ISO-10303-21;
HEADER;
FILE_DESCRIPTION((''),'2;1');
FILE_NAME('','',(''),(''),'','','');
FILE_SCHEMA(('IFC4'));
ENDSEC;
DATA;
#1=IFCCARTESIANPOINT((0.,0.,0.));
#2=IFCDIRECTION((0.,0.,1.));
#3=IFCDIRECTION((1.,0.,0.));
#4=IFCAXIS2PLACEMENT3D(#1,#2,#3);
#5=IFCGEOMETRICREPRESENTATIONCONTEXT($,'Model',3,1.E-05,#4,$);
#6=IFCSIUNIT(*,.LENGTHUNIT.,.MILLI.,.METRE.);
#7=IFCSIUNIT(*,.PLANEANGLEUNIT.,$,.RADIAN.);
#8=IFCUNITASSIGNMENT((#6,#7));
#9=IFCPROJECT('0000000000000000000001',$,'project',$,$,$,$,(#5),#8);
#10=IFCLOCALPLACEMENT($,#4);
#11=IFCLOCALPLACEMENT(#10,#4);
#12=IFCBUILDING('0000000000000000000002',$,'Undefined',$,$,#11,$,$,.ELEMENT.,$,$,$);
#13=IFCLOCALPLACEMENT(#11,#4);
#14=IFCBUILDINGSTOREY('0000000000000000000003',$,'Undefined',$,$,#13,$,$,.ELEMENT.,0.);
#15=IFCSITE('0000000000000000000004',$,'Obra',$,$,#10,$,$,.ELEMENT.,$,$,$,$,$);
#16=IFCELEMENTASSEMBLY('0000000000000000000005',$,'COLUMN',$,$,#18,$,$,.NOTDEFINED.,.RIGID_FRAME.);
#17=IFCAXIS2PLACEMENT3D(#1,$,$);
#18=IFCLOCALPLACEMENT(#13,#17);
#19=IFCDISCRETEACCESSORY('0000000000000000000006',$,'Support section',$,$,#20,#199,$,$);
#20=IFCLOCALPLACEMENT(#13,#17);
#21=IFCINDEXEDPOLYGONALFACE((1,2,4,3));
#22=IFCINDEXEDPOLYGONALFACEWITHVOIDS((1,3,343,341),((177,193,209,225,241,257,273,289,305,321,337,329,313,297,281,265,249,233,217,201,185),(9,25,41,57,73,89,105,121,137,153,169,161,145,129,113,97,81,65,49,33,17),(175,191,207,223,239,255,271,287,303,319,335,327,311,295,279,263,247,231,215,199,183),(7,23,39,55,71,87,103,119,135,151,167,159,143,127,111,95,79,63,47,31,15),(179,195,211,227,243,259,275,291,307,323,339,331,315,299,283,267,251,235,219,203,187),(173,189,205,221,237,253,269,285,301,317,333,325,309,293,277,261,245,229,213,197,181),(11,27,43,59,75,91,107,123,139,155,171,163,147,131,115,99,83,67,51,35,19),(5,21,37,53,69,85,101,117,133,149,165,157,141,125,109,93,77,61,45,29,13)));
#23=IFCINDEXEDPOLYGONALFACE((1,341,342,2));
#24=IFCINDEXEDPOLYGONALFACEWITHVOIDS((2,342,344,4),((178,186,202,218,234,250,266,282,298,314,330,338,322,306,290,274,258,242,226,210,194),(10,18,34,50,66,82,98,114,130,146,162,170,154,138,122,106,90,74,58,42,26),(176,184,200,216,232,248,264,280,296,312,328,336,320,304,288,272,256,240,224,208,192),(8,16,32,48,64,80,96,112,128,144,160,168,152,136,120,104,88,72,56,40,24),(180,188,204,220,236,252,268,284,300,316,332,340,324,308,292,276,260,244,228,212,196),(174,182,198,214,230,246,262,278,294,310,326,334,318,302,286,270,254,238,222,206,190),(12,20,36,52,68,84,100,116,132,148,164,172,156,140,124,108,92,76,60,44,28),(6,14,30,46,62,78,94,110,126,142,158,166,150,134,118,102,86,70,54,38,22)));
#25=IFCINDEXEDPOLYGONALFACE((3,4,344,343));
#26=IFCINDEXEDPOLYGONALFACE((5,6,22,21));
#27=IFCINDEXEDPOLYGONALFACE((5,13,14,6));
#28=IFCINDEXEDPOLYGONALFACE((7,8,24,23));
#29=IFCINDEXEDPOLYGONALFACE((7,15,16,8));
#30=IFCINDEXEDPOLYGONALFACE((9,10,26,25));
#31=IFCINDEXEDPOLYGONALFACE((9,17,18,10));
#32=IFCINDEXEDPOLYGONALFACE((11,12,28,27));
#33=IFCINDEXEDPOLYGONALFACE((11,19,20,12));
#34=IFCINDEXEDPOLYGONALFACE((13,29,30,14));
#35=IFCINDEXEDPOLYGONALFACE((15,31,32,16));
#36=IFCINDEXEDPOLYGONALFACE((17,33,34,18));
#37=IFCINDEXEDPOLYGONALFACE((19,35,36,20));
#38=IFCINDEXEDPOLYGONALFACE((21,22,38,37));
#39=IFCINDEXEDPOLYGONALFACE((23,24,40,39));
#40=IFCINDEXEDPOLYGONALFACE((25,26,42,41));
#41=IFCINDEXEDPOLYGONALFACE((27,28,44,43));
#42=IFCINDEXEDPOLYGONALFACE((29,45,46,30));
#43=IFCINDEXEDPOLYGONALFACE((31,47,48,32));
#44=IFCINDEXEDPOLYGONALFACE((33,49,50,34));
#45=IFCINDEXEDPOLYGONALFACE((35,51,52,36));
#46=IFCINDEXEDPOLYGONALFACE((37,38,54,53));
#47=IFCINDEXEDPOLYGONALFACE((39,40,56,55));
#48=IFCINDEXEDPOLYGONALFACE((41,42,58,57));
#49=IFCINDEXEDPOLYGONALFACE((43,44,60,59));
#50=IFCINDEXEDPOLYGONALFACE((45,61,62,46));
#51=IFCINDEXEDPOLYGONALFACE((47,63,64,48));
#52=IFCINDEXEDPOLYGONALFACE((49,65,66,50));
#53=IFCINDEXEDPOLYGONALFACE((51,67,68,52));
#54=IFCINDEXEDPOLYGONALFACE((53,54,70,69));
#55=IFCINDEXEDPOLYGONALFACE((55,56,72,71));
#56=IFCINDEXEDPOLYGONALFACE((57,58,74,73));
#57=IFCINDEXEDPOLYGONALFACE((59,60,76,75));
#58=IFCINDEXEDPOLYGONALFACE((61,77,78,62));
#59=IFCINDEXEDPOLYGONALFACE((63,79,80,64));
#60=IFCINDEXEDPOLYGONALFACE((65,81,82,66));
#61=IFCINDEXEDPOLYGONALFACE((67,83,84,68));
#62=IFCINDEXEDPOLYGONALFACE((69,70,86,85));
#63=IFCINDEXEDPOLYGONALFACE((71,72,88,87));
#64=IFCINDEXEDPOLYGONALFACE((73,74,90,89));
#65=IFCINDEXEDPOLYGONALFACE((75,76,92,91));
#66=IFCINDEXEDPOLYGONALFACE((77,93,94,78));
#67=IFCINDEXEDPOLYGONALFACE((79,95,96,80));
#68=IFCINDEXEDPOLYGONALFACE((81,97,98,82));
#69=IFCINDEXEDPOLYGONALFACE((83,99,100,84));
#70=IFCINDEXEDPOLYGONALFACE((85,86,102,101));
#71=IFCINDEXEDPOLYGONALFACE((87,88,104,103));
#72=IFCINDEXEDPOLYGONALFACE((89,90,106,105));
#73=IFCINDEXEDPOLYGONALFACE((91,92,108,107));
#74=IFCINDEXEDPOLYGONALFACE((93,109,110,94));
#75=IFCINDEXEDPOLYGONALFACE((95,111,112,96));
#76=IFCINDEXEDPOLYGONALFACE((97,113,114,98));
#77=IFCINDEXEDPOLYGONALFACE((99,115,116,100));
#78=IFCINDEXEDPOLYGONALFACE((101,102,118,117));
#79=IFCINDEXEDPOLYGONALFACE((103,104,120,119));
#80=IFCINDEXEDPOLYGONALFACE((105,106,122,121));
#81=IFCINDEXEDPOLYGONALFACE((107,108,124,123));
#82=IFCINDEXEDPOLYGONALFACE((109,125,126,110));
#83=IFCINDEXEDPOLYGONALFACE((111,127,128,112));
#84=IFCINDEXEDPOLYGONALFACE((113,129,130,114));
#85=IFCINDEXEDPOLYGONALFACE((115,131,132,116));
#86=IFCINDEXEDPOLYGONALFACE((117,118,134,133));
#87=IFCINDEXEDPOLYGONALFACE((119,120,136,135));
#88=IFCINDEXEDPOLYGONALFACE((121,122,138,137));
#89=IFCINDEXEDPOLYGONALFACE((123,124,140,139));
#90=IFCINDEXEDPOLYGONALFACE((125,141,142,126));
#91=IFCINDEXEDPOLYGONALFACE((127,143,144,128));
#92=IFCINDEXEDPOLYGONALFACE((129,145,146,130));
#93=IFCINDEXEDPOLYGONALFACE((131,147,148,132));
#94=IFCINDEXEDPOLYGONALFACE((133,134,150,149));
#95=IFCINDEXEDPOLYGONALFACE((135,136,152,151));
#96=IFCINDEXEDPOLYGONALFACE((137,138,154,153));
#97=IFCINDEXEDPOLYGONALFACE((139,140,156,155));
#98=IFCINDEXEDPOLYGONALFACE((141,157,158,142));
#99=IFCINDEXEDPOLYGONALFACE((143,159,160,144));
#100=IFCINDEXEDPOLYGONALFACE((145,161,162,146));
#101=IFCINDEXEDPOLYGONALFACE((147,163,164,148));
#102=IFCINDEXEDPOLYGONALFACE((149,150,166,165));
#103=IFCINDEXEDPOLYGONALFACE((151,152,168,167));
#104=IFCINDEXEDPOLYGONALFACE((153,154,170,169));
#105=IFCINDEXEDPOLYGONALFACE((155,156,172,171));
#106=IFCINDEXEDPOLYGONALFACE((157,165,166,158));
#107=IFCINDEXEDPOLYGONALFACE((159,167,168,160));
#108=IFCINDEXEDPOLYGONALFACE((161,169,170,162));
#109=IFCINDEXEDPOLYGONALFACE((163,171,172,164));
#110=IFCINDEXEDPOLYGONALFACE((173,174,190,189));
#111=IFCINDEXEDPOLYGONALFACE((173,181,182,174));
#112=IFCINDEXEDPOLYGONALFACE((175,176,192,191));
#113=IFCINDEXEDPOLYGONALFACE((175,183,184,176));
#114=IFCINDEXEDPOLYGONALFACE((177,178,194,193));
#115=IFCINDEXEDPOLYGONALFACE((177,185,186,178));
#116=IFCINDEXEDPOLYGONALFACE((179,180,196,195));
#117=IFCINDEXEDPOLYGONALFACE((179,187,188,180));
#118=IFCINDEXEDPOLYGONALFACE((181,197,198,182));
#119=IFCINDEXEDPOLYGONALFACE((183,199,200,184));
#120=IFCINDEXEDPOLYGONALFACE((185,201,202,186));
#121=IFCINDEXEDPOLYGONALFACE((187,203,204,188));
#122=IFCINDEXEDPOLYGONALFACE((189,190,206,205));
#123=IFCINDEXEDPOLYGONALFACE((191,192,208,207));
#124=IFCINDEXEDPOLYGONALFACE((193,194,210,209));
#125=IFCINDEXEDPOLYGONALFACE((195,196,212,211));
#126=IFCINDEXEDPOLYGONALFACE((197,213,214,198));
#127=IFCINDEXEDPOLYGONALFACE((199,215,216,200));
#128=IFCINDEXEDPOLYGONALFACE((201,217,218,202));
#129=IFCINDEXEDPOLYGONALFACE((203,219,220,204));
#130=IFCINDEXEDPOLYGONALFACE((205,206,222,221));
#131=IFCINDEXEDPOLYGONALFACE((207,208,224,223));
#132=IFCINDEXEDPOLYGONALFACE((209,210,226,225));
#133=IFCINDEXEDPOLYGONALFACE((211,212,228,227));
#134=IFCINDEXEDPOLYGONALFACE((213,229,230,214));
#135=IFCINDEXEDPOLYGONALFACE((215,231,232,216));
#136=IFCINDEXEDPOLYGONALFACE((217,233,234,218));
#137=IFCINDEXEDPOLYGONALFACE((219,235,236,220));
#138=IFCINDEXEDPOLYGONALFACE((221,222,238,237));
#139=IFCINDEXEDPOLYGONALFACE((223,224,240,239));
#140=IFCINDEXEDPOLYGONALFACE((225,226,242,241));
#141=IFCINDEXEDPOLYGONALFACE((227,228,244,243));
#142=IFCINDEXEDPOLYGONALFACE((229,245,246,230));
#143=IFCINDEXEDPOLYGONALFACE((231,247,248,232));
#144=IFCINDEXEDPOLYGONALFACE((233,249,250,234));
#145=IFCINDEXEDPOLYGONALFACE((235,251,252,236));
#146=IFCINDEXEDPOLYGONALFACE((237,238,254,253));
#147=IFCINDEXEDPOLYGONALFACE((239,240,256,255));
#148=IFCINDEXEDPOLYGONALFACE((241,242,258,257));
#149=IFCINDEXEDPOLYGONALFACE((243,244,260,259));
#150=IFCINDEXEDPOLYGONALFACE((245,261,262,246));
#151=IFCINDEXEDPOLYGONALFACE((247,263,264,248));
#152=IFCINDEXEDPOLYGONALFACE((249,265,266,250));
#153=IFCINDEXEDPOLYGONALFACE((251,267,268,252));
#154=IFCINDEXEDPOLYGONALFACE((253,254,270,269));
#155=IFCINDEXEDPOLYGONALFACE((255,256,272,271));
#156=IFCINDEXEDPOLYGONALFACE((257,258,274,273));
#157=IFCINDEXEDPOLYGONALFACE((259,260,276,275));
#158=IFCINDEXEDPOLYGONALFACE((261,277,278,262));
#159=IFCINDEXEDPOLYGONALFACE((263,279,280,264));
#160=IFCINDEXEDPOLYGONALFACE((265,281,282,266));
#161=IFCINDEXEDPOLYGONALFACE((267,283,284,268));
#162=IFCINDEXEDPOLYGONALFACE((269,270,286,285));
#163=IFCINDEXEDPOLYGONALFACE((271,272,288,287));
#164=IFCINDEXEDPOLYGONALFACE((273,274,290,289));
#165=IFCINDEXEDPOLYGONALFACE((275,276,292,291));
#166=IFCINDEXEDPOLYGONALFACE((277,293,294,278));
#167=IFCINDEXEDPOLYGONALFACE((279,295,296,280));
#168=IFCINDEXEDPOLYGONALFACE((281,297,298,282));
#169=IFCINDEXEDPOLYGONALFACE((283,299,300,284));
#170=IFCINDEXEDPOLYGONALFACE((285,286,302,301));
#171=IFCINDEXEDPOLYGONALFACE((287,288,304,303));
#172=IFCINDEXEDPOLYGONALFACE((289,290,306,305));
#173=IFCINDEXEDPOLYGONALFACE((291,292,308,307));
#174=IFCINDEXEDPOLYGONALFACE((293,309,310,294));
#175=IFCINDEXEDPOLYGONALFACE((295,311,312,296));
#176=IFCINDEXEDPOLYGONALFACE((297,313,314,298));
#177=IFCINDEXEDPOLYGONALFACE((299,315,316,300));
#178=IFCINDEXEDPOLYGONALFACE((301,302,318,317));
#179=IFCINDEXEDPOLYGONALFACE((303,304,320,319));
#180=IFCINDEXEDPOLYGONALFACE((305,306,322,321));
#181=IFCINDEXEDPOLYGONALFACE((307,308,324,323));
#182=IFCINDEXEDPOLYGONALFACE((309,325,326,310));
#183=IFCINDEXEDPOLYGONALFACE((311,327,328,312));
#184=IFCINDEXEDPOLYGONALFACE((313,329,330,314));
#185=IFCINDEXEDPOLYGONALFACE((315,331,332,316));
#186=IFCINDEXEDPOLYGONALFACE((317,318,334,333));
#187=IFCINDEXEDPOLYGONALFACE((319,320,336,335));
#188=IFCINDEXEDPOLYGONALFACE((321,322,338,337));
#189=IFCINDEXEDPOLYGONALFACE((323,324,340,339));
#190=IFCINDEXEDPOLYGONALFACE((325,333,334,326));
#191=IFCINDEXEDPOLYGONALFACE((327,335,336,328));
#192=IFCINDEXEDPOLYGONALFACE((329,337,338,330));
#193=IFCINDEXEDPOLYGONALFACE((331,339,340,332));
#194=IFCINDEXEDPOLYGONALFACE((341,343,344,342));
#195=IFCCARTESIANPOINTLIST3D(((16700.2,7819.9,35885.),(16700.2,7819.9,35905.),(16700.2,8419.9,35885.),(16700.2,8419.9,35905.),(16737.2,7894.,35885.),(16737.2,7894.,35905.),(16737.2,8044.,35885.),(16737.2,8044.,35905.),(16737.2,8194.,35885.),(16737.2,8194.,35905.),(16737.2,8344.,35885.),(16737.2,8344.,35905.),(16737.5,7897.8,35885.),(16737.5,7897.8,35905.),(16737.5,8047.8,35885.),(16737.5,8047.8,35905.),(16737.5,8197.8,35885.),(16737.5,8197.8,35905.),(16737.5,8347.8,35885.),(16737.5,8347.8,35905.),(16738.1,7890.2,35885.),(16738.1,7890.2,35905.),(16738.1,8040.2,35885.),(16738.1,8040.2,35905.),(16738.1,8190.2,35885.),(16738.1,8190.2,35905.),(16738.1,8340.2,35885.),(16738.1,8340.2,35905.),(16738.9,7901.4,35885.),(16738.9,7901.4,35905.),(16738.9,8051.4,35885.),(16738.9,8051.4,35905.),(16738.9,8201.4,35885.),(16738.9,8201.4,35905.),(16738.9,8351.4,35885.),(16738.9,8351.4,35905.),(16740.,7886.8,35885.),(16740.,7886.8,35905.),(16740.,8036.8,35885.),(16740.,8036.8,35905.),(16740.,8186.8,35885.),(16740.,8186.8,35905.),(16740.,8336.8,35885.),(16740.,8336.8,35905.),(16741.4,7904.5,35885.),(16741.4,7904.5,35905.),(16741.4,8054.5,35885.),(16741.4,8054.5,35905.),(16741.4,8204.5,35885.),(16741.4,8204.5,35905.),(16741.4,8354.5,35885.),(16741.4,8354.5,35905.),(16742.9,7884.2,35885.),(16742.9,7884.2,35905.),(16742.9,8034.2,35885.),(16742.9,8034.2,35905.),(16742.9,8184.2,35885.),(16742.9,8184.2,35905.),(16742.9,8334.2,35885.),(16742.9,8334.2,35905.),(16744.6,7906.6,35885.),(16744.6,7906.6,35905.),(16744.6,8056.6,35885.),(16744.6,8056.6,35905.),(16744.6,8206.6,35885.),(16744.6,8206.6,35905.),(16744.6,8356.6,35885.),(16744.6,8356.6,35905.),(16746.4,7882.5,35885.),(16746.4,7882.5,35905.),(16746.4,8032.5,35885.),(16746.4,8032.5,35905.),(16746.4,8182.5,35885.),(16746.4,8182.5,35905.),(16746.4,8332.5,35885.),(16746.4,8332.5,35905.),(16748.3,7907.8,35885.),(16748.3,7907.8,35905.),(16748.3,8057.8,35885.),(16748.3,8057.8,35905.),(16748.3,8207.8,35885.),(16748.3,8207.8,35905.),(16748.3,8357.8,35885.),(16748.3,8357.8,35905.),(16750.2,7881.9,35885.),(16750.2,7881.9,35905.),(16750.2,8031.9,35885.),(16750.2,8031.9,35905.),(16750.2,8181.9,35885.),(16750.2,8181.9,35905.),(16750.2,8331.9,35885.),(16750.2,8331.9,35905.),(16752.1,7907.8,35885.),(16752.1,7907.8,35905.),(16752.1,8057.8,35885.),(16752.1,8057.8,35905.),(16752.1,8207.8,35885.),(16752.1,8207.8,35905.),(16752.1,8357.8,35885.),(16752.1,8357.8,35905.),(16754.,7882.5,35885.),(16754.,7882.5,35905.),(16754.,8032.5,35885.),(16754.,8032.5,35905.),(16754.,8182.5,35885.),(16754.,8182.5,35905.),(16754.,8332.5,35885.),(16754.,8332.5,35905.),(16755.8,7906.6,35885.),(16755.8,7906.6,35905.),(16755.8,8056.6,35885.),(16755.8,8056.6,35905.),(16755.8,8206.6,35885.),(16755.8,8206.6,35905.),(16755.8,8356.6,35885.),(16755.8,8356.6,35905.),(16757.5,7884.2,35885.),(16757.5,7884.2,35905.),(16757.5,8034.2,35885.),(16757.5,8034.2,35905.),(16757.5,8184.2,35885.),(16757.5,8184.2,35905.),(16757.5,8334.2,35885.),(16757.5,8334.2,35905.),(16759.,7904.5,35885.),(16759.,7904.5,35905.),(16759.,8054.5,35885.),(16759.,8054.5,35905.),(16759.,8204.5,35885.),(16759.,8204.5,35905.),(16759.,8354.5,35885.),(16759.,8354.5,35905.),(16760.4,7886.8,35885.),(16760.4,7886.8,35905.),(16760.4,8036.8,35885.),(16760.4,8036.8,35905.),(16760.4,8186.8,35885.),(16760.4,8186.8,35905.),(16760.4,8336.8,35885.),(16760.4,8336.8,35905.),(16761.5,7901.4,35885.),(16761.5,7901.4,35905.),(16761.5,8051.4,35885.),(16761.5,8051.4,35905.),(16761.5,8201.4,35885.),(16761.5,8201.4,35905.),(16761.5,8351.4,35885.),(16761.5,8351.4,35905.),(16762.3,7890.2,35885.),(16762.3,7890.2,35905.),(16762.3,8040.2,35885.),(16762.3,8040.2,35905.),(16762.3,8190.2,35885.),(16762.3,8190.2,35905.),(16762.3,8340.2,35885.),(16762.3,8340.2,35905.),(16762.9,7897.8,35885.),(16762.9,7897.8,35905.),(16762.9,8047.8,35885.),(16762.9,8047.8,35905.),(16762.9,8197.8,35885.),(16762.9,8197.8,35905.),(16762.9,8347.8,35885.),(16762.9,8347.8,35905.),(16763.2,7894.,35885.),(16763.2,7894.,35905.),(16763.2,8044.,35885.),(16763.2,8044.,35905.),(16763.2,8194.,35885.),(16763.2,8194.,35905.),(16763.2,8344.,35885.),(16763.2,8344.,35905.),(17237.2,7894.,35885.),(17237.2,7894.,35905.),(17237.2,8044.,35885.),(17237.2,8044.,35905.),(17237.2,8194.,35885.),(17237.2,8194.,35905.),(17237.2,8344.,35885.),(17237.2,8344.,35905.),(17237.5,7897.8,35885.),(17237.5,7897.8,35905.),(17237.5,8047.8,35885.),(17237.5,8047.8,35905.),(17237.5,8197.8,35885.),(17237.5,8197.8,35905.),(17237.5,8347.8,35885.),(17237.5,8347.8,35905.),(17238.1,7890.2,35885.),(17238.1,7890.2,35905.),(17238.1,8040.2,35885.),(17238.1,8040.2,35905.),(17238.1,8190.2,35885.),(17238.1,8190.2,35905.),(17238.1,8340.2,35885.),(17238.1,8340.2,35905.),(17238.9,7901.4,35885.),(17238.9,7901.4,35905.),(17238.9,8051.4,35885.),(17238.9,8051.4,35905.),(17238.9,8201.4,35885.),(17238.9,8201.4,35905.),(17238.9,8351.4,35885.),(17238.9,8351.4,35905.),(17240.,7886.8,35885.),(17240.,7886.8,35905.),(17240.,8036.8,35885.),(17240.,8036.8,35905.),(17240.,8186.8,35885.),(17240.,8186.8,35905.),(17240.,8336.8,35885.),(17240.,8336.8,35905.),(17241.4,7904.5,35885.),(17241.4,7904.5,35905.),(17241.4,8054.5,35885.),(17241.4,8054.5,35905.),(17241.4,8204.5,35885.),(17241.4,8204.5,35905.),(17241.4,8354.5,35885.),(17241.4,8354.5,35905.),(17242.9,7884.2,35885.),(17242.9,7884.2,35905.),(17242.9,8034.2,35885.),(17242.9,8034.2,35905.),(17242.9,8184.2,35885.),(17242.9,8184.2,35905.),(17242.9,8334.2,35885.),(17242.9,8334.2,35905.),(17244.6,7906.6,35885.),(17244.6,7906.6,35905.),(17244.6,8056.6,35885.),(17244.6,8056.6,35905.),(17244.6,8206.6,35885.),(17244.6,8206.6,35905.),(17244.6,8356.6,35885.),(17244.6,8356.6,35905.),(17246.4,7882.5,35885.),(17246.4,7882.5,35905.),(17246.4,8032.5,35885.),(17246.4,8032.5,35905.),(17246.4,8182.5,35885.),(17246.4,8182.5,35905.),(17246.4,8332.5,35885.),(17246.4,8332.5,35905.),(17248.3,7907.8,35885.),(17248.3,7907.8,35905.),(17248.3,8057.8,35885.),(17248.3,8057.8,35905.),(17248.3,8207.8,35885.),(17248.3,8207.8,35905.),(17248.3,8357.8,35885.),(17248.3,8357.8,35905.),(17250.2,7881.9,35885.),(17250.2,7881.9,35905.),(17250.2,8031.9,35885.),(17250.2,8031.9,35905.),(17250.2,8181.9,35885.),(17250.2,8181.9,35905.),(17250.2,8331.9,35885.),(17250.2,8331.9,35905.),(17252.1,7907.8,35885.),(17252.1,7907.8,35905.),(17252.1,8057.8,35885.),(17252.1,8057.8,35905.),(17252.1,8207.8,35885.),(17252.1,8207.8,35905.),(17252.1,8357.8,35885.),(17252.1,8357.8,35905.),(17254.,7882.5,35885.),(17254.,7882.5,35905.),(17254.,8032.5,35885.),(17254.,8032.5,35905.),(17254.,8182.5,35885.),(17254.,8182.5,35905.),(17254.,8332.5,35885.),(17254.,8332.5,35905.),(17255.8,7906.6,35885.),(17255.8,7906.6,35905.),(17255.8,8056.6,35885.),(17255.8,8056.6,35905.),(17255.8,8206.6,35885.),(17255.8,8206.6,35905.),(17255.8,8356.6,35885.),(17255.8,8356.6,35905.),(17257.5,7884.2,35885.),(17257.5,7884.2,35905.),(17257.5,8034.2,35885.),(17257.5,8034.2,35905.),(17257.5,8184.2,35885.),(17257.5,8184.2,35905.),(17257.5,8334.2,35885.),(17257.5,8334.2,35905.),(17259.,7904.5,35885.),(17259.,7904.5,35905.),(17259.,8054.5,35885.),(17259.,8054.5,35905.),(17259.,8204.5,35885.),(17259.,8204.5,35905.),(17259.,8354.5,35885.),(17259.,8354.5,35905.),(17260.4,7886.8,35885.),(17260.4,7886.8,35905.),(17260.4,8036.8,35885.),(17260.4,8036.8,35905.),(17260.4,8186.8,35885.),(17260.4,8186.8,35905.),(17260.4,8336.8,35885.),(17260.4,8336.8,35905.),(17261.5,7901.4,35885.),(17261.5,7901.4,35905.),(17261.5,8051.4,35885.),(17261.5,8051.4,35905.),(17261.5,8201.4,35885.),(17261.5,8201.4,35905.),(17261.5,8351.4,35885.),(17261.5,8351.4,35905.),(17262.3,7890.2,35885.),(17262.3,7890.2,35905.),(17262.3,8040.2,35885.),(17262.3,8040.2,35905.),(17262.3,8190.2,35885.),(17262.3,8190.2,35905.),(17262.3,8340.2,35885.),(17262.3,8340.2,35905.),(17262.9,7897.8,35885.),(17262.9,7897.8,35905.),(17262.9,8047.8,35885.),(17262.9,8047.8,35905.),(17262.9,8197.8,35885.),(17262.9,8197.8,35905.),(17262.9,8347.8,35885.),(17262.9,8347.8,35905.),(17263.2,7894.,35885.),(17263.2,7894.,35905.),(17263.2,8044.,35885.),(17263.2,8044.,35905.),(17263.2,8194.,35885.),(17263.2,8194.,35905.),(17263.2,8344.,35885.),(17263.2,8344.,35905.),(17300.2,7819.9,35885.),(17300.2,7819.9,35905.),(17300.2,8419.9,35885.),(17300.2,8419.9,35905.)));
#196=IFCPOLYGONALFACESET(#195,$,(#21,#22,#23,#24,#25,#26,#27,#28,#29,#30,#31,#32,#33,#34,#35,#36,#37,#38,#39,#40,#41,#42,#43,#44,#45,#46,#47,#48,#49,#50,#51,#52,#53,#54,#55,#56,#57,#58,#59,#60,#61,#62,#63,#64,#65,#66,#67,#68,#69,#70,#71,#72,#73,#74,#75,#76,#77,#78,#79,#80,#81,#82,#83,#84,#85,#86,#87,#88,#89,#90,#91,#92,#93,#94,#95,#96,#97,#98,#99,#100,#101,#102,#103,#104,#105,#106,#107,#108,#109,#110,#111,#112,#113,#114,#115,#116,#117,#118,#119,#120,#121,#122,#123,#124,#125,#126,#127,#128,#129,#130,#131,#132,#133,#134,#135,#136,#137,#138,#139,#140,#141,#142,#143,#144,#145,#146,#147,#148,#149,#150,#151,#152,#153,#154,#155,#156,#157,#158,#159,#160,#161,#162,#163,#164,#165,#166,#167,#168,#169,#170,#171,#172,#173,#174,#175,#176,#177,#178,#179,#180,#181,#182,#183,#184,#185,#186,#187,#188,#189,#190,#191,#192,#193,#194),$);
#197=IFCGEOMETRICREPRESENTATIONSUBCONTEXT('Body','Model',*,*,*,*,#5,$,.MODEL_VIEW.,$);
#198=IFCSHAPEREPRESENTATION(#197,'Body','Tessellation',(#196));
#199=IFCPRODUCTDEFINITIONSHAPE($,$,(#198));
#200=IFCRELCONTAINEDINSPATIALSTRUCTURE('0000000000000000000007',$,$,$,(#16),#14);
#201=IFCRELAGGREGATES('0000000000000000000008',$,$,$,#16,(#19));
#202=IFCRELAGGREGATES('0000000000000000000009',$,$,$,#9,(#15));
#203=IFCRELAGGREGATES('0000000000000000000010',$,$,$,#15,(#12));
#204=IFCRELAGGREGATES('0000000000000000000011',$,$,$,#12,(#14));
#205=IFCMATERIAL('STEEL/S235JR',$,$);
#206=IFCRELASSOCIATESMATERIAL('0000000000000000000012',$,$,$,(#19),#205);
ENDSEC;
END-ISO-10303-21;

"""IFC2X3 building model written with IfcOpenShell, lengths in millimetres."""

from ifc_helpers import new_model, si_unit, frame, origin_with_axes, origin_2d_with_axis, place, context, subcontext, project, spatial, rectangle, circle, extrude, source, transform, mapped, material, element, aggregate, save


model = new_model("IFC2X3")

# Units and contexts
model_context = context("Model", 3, precision=1e-05, world=origin_with_axes())
body_context = subcontext(model_context, "Body", "Model", "MODEL_VIEW")
ifc_project = project(units=[si_unit("LENGTHUNIT", "METRE", prefix="MILLI"), si_unit("PLANEANGLEUNIT", "RADIAN")], contexts=[model_context])

# Site, building, storey
site_placement = place(None, origin_with_axes())
site = spatial("IfcSite", under=ifc_project, at=site_placement, Name="Obra", CompositionType="ELEMENT")
building_placement = place(site_placement, origin_with_axes())
building = spatial("IfcBuilding", under=site, at=building_placement, Name="Undefined", CompositionType="ELEMENT")
storey_placement = place(building_placement, origin_with_axes())
storey = spatial("IfcBuildingStorey", under=building, at=storey_placement, Name="Undefined", CompositionType="ELEMENT", Elevation=0.0)

# Element assembly
assembly_1_placement = place(storey_placement, origin_with_axes())
assembly_1 = element("IfcElementAssembly", 1, at=assembly_1_placement, inside=storey, Name="COLUMN", AssemblyPlace="NOTDEFINED", PredefinedType="RIGID_FRAME")
ifc_material_1 = material(Name="STEEL/S235JR")

# Discrete accessory, opening
discrete_accessory_1_placement = place(assembly_1_placement, frame((17000.2, 7819.9, 35895.0), z_axis=(1.0, 0.0, 0.0), x_axis=(0.0, 1.0, 0.0)))
discrete_accessory_1 = element("IfcDiscreteAccessory", 2, at=discrete_accessory_1_placement, material=ifc_material_1, Name="Support section", context=body_context, shape_type="SweptSolid", body=[
    extrude(rectangle(XDim=20.0, YDim=600.0, at=origin_2d_with_axis()), frame((600.0, 0.0, 0.0), z_axis=(-1.0, 0.0, 0.0), x_axis=(0.0, -1.0, 0.0)), (0.0, 0.0, 1.0), 600.0),
])
shared_shape_1 = source(origin_with_axes(), body_context, "Body", "SweptSolid", [
    extrude(circle(Radius=13.0, at=origin_2d_with_axis()), frame((0.0, -0.1, 0.0), z_axis=(0.0, 1.0, 0.0), x_axis=(1.0, 0.0, 0.0)), (0.0, 0.0, 1.0), 20.2),
])
opening_1_placement = place(assembly_1_placement, frame((17000.2, 8322.9, 35905.0), z_axis=(1.0, 0.0, 0.0), x_axis=(0.0, -1.0, 0.0)))
element("IfcOpeningElement", 3, at=opening_1_placement, cuts=discrete_accessory_1, ObjectType="Opening", context=body_context, shape_type="MappedRepresentation", body=[
    mapped(shared_shape_1, transform((-22.0, 0.0, -250.0))),
    mapped(shared_shape_1, transform((-22.0, 0.0, 250.0))),
    mapped(shared_shape_1, transform((128.0, 0.0, -250.0))),
    mapped(shared_shape_1, transform((128.0, 0.0, 250.0))),
    mapped(shared_shape_1, transform((278.0, 0.0, -250.0))),
    mapped(shared_shape_1, transform((278.0, 0.0, 250.0))),
    mapped(shared_shape_1, transform((428.0, 0.0, -250.0))),
    mapped(shared_shape_1, transform((428.0, 0.0, 250.0))),
])

aggregate(assembly_1, [discrete_accessory_1])

save(model, "model.ifc")
